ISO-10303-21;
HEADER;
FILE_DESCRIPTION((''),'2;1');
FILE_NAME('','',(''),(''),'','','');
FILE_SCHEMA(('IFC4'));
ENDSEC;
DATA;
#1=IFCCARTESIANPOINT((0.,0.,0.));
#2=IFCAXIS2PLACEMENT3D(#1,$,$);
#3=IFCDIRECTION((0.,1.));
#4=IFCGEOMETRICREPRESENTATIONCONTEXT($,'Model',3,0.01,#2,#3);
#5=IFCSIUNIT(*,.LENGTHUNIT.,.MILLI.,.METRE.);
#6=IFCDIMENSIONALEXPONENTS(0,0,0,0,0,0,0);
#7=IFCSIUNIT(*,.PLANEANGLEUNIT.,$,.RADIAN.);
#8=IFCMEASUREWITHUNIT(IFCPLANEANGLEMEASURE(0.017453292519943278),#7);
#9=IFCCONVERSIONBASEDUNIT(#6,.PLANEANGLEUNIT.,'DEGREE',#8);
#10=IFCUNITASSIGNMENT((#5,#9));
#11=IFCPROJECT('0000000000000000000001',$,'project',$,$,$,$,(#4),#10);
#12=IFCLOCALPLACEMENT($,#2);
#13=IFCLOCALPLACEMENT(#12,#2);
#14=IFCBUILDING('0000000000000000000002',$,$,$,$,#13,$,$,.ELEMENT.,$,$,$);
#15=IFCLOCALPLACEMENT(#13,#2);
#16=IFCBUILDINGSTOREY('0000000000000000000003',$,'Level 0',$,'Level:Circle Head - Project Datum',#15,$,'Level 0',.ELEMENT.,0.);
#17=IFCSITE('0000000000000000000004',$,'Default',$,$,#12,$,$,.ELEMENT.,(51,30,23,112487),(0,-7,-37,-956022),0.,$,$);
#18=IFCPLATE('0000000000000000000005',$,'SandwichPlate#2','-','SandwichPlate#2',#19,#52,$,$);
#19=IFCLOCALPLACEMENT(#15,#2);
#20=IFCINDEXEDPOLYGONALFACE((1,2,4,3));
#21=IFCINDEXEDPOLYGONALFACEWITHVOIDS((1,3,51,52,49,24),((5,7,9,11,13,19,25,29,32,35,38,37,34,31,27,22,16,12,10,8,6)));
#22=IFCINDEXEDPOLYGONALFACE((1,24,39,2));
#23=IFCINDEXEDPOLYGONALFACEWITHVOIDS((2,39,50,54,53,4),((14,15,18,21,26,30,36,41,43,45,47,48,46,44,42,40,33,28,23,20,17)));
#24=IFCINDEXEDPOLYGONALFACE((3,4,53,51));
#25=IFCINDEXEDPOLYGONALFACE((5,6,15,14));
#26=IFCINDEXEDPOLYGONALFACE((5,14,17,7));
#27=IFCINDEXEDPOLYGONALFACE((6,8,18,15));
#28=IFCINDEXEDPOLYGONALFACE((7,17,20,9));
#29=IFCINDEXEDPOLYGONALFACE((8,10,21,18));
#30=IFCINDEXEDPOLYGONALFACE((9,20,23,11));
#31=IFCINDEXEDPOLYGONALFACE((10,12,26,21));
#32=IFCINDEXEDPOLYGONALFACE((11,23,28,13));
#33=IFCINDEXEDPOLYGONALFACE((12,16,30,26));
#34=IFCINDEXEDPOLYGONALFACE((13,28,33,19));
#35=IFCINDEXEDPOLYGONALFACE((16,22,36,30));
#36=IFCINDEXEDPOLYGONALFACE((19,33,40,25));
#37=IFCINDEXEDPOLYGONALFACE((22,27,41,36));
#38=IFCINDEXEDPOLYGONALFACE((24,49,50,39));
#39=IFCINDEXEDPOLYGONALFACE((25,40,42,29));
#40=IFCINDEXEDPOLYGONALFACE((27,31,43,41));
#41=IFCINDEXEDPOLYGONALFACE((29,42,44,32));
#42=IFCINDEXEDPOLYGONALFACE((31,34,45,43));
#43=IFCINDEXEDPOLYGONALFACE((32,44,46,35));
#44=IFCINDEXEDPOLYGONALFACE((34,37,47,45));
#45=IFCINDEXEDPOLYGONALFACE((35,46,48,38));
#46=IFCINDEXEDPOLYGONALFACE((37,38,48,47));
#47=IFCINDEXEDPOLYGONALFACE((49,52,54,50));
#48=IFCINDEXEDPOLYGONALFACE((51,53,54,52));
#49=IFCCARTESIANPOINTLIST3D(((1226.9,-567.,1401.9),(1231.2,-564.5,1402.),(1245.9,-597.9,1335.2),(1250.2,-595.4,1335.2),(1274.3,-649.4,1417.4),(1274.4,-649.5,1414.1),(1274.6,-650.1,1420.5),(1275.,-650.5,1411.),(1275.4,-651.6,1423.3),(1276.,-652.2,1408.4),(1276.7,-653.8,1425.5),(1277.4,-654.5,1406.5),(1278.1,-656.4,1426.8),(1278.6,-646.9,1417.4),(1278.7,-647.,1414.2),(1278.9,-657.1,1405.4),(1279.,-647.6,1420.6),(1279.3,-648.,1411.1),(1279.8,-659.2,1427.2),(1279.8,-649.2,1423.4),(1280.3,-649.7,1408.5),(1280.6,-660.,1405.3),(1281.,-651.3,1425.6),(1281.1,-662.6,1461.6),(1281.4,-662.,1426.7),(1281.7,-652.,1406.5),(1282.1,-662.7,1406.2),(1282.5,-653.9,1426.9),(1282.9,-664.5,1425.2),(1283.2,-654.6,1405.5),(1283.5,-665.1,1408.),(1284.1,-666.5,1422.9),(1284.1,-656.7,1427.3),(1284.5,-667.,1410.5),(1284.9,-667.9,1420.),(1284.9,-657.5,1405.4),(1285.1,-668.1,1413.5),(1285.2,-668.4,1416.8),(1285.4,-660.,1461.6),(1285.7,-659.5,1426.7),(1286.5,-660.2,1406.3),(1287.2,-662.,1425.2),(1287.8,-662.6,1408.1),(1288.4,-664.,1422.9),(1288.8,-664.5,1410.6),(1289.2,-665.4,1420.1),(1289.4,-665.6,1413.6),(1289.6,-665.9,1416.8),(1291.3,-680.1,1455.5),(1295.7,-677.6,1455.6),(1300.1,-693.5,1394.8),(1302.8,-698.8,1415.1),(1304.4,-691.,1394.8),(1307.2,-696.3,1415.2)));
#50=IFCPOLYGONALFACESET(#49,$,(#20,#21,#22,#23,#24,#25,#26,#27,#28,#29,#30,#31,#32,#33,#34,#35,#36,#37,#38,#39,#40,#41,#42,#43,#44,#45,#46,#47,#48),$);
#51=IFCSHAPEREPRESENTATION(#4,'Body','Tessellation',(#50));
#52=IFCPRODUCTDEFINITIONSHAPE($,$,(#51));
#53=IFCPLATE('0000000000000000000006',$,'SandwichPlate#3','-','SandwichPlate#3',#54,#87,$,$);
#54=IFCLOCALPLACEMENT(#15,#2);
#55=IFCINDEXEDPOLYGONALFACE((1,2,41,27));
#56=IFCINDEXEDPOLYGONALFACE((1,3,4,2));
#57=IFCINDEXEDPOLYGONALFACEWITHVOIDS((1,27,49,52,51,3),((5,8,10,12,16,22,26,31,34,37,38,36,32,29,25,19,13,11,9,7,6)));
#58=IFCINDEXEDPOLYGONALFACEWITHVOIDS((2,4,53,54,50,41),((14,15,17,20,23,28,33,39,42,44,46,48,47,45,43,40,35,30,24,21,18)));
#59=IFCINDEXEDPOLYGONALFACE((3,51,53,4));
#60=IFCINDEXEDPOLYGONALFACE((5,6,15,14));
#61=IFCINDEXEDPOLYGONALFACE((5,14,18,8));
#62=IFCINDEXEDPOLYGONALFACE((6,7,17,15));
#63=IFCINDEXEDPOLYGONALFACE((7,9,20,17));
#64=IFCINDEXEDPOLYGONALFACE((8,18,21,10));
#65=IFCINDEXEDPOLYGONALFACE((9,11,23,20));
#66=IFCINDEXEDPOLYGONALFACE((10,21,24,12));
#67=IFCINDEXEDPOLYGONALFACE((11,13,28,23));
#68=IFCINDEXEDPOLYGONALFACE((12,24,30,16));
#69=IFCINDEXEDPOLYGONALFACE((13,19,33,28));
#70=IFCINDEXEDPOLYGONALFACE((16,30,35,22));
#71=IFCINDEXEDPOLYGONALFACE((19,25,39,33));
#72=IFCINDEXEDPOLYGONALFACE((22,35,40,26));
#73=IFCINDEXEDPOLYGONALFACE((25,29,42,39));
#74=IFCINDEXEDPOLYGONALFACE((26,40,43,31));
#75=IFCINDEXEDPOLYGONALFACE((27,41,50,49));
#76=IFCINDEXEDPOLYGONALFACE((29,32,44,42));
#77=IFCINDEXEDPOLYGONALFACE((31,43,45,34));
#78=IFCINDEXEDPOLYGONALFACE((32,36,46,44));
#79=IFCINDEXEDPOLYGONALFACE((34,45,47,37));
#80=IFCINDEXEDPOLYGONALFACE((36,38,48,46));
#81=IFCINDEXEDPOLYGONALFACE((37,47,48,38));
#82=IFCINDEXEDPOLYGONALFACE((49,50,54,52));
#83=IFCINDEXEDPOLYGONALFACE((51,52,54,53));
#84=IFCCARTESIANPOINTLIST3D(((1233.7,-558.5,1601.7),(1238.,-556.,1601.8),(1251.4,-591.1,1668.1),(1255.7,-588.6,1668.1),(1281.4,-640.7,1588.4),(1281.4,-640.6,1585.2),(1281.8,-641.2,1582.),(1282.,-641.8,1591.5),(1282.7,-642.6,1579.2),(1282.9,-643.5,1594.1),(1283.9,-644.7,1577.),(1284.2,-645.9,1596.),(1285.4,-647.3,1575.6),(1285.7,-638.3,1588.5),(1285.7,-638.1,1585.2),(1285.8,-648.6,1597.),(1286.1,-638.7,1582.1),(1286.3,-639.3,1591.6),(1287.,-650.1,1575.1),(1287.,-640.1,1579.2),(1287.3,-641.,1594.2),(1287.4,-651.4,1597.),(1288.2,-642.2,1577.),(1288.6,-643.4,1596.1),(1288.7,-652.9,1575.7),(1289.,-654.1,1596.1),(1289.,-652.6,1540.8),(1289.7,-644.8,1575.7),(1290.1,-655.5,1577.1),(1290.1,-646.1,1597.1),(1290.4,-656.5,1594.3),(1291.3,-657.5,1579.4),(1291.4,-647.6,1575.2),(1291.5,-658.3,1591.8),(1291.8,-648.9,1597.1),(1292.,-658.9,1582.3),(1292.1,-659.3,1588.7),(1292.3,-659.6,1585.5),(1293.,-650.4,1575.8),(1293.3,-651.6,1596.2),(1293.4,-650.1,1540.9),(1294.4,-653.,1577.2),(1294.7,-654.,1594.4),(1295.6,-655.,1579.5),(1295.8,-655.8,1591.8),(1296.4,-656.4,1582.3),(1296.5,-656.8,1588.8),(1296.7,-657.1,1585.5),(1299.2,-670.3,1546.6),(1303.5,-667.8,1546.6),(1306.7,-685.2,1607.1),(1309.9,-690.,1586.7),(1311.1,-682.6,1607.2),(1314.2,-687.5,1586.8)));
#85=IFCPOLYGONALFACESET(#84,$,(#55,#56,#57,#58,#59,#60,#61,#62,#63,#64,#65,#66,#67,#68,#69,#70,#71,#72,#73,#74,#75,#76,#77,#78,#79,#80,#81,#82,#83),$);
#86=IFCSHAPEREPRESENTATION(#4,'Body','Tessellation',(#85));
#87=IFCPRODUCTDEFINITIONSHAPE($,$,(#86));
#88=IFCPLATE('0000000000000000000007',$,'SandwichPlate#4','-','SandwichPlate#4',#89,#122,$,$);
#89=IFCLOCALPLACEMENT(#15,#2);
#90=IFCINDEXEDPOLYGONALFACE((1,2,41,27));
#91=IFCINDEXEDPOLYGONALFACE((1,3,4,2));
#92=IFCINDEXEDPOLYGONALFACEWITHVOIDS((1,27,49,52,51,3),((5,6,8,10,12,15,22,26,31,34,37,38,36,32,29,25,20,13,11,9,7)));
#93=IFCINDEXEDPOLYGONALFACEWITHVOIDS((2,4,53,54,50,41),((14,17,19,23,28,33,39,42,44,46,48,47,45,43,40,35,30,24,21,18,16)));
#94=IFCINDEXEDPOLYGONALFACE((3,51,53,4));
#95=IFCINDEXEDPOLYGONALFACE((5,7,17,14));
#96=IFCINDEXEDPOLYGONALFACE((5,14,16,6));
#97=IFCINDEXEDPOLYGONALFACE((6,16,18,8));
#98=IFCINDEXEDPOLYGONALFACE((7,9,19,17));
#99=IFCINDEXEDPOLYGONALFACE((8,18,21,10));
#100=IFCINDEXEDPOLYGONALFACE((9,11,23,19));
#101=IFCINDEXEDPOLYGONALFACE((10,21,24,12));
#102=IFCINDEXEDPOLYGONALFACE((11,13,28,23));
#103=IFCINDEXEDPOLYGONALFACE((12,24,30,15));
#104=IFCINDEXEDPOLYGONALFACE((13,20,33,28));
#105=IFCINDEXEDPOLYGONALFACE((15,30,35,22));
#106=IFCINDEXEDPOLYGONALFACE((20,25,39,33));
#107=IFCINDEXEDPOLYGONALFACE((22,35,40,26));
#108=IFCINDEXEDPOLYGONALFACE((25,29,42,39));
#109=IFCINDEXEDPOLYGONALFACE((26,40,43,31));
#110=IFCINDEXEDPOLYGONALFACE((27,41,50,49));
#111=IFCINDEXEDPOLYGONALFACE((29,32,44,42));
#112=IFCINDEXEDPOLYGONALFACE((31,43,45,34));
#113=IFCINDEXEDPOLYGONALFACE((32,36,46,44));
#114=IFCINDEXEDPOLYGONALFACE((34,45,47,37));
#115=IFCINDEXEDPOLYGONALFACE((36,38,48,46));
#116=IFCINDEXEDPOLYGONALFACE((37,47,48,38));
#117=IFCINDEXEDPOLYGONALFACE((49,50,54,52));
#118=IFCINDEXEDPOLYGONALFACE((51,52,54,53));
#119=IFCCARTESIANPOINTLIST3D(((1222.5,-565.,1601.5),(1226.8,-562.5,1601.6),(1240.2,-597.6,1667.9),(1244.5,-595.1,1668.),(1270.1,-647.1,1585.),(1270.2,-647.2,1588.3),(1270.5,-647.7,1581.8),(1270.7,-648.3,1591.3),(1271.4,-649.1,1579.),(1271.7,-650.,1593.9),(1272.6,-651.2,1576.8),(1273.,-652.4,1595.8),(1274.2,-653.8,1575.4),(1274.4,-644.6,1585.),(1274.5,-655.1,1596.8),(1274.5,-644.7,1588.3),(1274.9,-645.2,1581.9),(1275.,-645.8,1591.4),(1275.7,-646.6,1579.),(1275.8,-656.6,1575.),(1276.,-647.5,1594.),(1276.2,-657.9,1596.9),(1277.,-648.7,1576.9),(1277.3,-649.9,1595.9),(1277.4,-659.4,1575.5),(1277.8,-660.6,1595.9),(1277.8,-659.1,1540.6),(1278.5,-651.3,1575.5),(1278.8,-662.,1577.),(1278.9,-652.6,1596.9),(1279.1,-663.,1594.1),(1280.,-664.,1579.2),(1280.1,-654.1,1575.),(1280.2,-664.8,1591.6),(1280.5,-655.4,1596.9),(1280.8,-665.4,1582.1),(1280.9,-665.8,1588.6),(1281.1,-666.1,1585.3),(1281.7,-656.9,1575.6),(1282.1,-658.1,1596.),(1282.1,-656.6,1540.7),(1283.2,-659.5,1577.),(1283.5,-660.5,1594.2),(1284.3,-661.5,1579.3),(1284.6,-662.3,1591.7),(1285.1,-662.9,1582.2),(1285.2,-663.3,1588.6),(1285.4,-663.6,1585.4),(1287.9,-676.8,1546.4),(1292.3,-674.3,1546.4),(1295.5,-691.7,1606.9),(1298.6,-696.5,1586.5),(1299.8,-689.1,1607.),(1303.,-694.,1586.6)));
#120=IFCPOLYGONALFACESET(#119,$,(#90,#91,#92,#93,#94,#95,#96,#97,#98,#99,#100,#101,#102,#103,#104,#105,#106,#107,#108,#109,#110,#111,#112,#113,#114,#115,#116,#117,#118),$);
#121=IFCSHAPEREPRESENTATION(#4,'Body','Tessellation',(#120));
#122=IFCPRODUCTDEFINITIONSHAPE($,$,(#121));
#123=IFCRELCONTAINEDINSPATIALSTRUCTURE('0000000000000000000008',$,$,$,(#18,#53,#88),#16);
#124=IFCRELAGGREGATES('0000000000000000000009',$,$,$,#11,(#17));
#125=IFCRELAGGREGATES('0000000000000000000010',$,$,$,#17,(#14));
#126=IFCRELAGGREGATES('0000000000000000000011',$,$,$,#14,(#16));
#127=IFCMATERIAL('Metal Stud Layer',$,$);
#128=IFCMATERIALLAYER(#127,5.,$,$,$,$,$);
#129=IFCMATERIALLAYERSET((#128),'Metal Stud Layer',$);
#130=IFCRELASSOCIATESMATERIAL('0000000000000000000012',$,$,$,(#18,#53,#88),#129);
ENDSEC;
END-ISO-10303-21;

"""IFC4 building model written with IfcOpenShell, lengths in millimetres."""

from ifc_helpers import new_model, entity, si_unit, converted_unit, direction, frame, origin, origin_with_axes, origin_2d_with_axis, place, context, project, spatial, polyline, circle, outline, extrude, material, layer, layer_set, element, save


model = new_model("IFC4")

# Units and contexts
model_context = context("Model", 3, precision=0.01, world=origin(), true_north=direction((0.0, 1.0)))
ifc_project = project(units=[si_unit("LENGTHUNIT", "METRE", prefix="MILLI"), converted_unit("PLANEANGLEUNIT", "DEGREE", entity("IfcPlaneAngleMeasure", 0.017453292519943278), si_unit("PLANEANGLEUNIT", "RADIAN"), dimensions=[0, 0, 0, 0, 0, 0, 0])], contexts=[model_context])

# Site, building, storey
site_placement = place(None, origin())
site = spatial("IfcSite", under=ifc_project, at=site_placement, Name="Default", CompositionType="ELEMENT", RefLatitude=(51, 30, 23, 112487), RefLongitude=(0, -7, -37, -956022), RefElevation=0.0)
building_placement = place(site_placement, origin())
building = spatial("IfcBuilding", under=site, at=building_placement, CompositionType="ELEMENT")
storey_placement = place(building_placement, origin())
storey = spatial("IfcBuildingStorey", under=building, at=storey_placement, Name="Level 0", ObjectType="Level:Circle Head - Project Datum", LongName="Level 0", CompositionType="ELEMENT", Elevation=0.0)

# Shared definitions
ifc_material_1 = material(Name="Metal Stud Layer")

# Shared definitions
ifc_layer_1 = layer(ifc_material_1, 5.0)
ifc_layer_set_1 = layer_set([ifc_layer_1], Name="Metal Stud Layer")

# Plates, openings
plate_1_placement = place(storey_placement, frame((1310.9, -702.4, 1402.0), z_axis=(-0.865935, -0.499948, -0.014432), x_axis=(-0.249453, 0.406695, 0.878847)))
plate_1 = element("IfcPlate", 1, at=plate_1_placement, inside=storey, material=ifc_layer_set_1, Name="SandwichPlate#2", Description="-", ObjectType="SandwichPlate#2", context=model_context, shape_type="SweptSolid", body=[
    extrude(outline(polyline([(0.0, 0.0), (76.0, 0.0), (76.0, 140.0), (0.0, 140.0), (0.0, 0.0)])), origin_with_axes(), (0.0, 0.0, 1.0), 5.0),
])
opening_1_placement = place(plate_1_placement, frame((0.0, 0.0, 0.0), z_axis=(0.0, 0.0, 1.0), x_axis=(1.0, 0.0, 0.0)))
element("IfcOpeningElement", 2, at=opening_1_placement, cuts=plate_1, ObjectType="Opening", context=model_context, shape_type="SweptSolid", body=[
    extrude(outline(polyline([(0.0, 0.0), (15.0, 0.0), (0.0, 15.0), (0.0, 0.0)])), origin(), (0.0, 0.0, 1.0), 5.0),
])
opening_2_placement = place(plate_1_placement, frame((0.0, 0.0, 0.0), z_axis=(0.0, 0.0, 1.0), x_axis=(1.0, 0.0, 0.0)))
element("IfcOpeningElement", 3, at=opening_2_placement, cuts=plate_1, ObjectType="Opening", context=model_context, shape_type="SweptSolid", body=[
    extrude(outline(polyline([(76.0, 0.0), (76.0, 15.0), (61.0, 0.0), (76.0, 0.0)])), origin(), (0.0, 0.0, 1.0), 5.0),
])
opening_3_placement = place(plate_1_placement, frame((38.0, 40.0, -0.5), z_axis=(0.0, 0.0, 1.0), x_axis=(0.0, 1.0, 0.0)))
element("IfcOpeningElement", 4, at=opening_3_placement, cuts=plate_1, ObjectType="Opening", context=model_context, shape_type="SweptSolid", body=[
    extrude(circle(Radius=11.0, at=origin_2d_with_axis()), origin(), (0.0, 0.0, 1.0), 6.0),
])
plate_2_placement = place(storey_placement, frame((1300.0, -661.4, 1533.5), z_axis=(-0.865935, -0.499948, -0.014432), x_axis=(0.232925, -0.428638, 0.872935)))
plate_2 = element("IfcPlate", 5, at=plate_2_placement, inside=storey, material=ifc_layer_set_1, Name="SandwichPlate#3", Description="-", ObjectType="SandwichPlate#3", context=model_context, shape_type="SweptSolid", body=[
    extrude(outline(polyline([(0.0, 0.0), (76.0, 0.0), (76.0, 140.0), (0.0, 140.0), (0.0, 0.0)])), origin_with_axes(), (0.0, 0.0, 1.0), 5.0),
])
opening_4_placement = place(plate_2_placement, frame((0.0, 0.0, 0.0), z_axis=(0.0, 0.0, 1.0), x_axis=(1.0, 0.0, 0.0)))
element("IfcOpeningElement", 6, at=opening_4_placement, cuts=plate_2, ObjectType="Opening", context=model_context, shape_type="SweptSolid", body=[
    extrude(outline(polyline([(0.0, 0.0), (15.0, 0.0), (0.0, 15.0), (0.0, 0.0)])), origin(), (0.0, 0.0, 1.0), 5.0),
])
opening_5_placement = place(plate_2_placement, frame((0.0, 0.0, 0.0), z_axis=(0.0, 0.0, 1.0), x_axis=(1.0, 0.0, 0.0)))
element("IfcOpeningElement", 7, at=opening_5_placement, cuts=plate_2, ObjectType="Opening", context=model_context, shape_type="SweptSolid", body=[
    extrude(outline(polyline([(76.0, 0.0), (76.0, 15.0), (61.0, 0.0), (76.0, 0.0)])), origin(), (0.0, 0.0, 1.0), 5.0),
])
opening_6_placement = place(plate_2_placement, frame((38.0, 40.0, -0.5), z_axis=(0.0, 0.0, 1.0), x_axis=(0.0, 1.0, 0.0)))
element("IfcOpeningElement", 8, at=opening_6_placement, cuts=plate_2, ObjectType="Opening", context=model_context, shape_type="SweptSolid", body=[
    extrude(circle(Radius=11.0, at=origin_2d_with_axis()), origin(), (0.0, 0.0, 1.0), 6.0),
])
plate_3_placement = place(storey_placement, frame((1288.7, -667.9, 1533.4), z_axis=(-0.865935, -0.499948, -0.014432), x_axis=(0.232925, -0.428638, 0.872935)))
plate_3 = element("IfcPlate", 9, at=plate_3_placement, inside=storey, material=ifc_layer_set_1, Name="SandwichPlate#4", Description="-", ObjectType="SandwichPlate#4", context=model_context, shape_type="SweptSolid", body=[
    extrude(outline(polyline([(0.0, 0.0), (76.0, 0.0), (76.0, 140.0), (0.0, 140.0), (0.0, 0.0)])), origin_with_axes(), (0.0, 0.0, 1.0), 5.0),
])
opening_7_placement = place(plate_3_placement, frame((0.0, 0.0, 0.0), z_axis=(0.0, 0.0, 1.0), x_axis=(1.0, 0.0, 0.0)))
element("IfcOpeningElement", 10, at=opening_7_placement, cuts=plate_3, ObjectType="Opening", context=model_context, shape_type="SweptSolid", body=[
    extrude(outline(polyline([(0.0, 0.0), (15.0, 0.0), (0.0, 15.0), (0.0, 0.0)])), origin(), (0.0, 0.0, 1.0), 5.0),
])
opening_8_placement = place(plate_3_placement, frame((0.0, 0.0, 0.0), z_axis=(0.0, 0.0, 1.0), x_axis=(1.0, 0.0, 0.0)))
element("IfcOpeningElement", 11, at=opening_8_placement, cuts=plate_3, ObjectType="Opening", context=model_context, shape_type="SweptSolid", body=[
    extrude(outline(polyline([(76.0, 0.0), (76.0, 15.0), (61.0, 0.0), (76.0, 0.0)])), origin(), (0.0, 0.0, 1.0), 5.0),
])
opening_9_placement = place(plate_3_placement, frame((38.0, 40.0, -0.5), z_axis=(0.0, 0.0, 1.0), x_axis=(0.0, 1.0, 0.0)))
element("IfcOpeningElement", 12, at=opening_9_placement, cuts=plate_3, ObjectType="Opening", context=model_context, shape_type="SweptSolid", body=[
    extrude(circle(Radius=11.0, at=origin_2d_with_axis()), origin(), (0.0, 0.0, 1.0), 6.0),
])

save(model, "model.ifc")
